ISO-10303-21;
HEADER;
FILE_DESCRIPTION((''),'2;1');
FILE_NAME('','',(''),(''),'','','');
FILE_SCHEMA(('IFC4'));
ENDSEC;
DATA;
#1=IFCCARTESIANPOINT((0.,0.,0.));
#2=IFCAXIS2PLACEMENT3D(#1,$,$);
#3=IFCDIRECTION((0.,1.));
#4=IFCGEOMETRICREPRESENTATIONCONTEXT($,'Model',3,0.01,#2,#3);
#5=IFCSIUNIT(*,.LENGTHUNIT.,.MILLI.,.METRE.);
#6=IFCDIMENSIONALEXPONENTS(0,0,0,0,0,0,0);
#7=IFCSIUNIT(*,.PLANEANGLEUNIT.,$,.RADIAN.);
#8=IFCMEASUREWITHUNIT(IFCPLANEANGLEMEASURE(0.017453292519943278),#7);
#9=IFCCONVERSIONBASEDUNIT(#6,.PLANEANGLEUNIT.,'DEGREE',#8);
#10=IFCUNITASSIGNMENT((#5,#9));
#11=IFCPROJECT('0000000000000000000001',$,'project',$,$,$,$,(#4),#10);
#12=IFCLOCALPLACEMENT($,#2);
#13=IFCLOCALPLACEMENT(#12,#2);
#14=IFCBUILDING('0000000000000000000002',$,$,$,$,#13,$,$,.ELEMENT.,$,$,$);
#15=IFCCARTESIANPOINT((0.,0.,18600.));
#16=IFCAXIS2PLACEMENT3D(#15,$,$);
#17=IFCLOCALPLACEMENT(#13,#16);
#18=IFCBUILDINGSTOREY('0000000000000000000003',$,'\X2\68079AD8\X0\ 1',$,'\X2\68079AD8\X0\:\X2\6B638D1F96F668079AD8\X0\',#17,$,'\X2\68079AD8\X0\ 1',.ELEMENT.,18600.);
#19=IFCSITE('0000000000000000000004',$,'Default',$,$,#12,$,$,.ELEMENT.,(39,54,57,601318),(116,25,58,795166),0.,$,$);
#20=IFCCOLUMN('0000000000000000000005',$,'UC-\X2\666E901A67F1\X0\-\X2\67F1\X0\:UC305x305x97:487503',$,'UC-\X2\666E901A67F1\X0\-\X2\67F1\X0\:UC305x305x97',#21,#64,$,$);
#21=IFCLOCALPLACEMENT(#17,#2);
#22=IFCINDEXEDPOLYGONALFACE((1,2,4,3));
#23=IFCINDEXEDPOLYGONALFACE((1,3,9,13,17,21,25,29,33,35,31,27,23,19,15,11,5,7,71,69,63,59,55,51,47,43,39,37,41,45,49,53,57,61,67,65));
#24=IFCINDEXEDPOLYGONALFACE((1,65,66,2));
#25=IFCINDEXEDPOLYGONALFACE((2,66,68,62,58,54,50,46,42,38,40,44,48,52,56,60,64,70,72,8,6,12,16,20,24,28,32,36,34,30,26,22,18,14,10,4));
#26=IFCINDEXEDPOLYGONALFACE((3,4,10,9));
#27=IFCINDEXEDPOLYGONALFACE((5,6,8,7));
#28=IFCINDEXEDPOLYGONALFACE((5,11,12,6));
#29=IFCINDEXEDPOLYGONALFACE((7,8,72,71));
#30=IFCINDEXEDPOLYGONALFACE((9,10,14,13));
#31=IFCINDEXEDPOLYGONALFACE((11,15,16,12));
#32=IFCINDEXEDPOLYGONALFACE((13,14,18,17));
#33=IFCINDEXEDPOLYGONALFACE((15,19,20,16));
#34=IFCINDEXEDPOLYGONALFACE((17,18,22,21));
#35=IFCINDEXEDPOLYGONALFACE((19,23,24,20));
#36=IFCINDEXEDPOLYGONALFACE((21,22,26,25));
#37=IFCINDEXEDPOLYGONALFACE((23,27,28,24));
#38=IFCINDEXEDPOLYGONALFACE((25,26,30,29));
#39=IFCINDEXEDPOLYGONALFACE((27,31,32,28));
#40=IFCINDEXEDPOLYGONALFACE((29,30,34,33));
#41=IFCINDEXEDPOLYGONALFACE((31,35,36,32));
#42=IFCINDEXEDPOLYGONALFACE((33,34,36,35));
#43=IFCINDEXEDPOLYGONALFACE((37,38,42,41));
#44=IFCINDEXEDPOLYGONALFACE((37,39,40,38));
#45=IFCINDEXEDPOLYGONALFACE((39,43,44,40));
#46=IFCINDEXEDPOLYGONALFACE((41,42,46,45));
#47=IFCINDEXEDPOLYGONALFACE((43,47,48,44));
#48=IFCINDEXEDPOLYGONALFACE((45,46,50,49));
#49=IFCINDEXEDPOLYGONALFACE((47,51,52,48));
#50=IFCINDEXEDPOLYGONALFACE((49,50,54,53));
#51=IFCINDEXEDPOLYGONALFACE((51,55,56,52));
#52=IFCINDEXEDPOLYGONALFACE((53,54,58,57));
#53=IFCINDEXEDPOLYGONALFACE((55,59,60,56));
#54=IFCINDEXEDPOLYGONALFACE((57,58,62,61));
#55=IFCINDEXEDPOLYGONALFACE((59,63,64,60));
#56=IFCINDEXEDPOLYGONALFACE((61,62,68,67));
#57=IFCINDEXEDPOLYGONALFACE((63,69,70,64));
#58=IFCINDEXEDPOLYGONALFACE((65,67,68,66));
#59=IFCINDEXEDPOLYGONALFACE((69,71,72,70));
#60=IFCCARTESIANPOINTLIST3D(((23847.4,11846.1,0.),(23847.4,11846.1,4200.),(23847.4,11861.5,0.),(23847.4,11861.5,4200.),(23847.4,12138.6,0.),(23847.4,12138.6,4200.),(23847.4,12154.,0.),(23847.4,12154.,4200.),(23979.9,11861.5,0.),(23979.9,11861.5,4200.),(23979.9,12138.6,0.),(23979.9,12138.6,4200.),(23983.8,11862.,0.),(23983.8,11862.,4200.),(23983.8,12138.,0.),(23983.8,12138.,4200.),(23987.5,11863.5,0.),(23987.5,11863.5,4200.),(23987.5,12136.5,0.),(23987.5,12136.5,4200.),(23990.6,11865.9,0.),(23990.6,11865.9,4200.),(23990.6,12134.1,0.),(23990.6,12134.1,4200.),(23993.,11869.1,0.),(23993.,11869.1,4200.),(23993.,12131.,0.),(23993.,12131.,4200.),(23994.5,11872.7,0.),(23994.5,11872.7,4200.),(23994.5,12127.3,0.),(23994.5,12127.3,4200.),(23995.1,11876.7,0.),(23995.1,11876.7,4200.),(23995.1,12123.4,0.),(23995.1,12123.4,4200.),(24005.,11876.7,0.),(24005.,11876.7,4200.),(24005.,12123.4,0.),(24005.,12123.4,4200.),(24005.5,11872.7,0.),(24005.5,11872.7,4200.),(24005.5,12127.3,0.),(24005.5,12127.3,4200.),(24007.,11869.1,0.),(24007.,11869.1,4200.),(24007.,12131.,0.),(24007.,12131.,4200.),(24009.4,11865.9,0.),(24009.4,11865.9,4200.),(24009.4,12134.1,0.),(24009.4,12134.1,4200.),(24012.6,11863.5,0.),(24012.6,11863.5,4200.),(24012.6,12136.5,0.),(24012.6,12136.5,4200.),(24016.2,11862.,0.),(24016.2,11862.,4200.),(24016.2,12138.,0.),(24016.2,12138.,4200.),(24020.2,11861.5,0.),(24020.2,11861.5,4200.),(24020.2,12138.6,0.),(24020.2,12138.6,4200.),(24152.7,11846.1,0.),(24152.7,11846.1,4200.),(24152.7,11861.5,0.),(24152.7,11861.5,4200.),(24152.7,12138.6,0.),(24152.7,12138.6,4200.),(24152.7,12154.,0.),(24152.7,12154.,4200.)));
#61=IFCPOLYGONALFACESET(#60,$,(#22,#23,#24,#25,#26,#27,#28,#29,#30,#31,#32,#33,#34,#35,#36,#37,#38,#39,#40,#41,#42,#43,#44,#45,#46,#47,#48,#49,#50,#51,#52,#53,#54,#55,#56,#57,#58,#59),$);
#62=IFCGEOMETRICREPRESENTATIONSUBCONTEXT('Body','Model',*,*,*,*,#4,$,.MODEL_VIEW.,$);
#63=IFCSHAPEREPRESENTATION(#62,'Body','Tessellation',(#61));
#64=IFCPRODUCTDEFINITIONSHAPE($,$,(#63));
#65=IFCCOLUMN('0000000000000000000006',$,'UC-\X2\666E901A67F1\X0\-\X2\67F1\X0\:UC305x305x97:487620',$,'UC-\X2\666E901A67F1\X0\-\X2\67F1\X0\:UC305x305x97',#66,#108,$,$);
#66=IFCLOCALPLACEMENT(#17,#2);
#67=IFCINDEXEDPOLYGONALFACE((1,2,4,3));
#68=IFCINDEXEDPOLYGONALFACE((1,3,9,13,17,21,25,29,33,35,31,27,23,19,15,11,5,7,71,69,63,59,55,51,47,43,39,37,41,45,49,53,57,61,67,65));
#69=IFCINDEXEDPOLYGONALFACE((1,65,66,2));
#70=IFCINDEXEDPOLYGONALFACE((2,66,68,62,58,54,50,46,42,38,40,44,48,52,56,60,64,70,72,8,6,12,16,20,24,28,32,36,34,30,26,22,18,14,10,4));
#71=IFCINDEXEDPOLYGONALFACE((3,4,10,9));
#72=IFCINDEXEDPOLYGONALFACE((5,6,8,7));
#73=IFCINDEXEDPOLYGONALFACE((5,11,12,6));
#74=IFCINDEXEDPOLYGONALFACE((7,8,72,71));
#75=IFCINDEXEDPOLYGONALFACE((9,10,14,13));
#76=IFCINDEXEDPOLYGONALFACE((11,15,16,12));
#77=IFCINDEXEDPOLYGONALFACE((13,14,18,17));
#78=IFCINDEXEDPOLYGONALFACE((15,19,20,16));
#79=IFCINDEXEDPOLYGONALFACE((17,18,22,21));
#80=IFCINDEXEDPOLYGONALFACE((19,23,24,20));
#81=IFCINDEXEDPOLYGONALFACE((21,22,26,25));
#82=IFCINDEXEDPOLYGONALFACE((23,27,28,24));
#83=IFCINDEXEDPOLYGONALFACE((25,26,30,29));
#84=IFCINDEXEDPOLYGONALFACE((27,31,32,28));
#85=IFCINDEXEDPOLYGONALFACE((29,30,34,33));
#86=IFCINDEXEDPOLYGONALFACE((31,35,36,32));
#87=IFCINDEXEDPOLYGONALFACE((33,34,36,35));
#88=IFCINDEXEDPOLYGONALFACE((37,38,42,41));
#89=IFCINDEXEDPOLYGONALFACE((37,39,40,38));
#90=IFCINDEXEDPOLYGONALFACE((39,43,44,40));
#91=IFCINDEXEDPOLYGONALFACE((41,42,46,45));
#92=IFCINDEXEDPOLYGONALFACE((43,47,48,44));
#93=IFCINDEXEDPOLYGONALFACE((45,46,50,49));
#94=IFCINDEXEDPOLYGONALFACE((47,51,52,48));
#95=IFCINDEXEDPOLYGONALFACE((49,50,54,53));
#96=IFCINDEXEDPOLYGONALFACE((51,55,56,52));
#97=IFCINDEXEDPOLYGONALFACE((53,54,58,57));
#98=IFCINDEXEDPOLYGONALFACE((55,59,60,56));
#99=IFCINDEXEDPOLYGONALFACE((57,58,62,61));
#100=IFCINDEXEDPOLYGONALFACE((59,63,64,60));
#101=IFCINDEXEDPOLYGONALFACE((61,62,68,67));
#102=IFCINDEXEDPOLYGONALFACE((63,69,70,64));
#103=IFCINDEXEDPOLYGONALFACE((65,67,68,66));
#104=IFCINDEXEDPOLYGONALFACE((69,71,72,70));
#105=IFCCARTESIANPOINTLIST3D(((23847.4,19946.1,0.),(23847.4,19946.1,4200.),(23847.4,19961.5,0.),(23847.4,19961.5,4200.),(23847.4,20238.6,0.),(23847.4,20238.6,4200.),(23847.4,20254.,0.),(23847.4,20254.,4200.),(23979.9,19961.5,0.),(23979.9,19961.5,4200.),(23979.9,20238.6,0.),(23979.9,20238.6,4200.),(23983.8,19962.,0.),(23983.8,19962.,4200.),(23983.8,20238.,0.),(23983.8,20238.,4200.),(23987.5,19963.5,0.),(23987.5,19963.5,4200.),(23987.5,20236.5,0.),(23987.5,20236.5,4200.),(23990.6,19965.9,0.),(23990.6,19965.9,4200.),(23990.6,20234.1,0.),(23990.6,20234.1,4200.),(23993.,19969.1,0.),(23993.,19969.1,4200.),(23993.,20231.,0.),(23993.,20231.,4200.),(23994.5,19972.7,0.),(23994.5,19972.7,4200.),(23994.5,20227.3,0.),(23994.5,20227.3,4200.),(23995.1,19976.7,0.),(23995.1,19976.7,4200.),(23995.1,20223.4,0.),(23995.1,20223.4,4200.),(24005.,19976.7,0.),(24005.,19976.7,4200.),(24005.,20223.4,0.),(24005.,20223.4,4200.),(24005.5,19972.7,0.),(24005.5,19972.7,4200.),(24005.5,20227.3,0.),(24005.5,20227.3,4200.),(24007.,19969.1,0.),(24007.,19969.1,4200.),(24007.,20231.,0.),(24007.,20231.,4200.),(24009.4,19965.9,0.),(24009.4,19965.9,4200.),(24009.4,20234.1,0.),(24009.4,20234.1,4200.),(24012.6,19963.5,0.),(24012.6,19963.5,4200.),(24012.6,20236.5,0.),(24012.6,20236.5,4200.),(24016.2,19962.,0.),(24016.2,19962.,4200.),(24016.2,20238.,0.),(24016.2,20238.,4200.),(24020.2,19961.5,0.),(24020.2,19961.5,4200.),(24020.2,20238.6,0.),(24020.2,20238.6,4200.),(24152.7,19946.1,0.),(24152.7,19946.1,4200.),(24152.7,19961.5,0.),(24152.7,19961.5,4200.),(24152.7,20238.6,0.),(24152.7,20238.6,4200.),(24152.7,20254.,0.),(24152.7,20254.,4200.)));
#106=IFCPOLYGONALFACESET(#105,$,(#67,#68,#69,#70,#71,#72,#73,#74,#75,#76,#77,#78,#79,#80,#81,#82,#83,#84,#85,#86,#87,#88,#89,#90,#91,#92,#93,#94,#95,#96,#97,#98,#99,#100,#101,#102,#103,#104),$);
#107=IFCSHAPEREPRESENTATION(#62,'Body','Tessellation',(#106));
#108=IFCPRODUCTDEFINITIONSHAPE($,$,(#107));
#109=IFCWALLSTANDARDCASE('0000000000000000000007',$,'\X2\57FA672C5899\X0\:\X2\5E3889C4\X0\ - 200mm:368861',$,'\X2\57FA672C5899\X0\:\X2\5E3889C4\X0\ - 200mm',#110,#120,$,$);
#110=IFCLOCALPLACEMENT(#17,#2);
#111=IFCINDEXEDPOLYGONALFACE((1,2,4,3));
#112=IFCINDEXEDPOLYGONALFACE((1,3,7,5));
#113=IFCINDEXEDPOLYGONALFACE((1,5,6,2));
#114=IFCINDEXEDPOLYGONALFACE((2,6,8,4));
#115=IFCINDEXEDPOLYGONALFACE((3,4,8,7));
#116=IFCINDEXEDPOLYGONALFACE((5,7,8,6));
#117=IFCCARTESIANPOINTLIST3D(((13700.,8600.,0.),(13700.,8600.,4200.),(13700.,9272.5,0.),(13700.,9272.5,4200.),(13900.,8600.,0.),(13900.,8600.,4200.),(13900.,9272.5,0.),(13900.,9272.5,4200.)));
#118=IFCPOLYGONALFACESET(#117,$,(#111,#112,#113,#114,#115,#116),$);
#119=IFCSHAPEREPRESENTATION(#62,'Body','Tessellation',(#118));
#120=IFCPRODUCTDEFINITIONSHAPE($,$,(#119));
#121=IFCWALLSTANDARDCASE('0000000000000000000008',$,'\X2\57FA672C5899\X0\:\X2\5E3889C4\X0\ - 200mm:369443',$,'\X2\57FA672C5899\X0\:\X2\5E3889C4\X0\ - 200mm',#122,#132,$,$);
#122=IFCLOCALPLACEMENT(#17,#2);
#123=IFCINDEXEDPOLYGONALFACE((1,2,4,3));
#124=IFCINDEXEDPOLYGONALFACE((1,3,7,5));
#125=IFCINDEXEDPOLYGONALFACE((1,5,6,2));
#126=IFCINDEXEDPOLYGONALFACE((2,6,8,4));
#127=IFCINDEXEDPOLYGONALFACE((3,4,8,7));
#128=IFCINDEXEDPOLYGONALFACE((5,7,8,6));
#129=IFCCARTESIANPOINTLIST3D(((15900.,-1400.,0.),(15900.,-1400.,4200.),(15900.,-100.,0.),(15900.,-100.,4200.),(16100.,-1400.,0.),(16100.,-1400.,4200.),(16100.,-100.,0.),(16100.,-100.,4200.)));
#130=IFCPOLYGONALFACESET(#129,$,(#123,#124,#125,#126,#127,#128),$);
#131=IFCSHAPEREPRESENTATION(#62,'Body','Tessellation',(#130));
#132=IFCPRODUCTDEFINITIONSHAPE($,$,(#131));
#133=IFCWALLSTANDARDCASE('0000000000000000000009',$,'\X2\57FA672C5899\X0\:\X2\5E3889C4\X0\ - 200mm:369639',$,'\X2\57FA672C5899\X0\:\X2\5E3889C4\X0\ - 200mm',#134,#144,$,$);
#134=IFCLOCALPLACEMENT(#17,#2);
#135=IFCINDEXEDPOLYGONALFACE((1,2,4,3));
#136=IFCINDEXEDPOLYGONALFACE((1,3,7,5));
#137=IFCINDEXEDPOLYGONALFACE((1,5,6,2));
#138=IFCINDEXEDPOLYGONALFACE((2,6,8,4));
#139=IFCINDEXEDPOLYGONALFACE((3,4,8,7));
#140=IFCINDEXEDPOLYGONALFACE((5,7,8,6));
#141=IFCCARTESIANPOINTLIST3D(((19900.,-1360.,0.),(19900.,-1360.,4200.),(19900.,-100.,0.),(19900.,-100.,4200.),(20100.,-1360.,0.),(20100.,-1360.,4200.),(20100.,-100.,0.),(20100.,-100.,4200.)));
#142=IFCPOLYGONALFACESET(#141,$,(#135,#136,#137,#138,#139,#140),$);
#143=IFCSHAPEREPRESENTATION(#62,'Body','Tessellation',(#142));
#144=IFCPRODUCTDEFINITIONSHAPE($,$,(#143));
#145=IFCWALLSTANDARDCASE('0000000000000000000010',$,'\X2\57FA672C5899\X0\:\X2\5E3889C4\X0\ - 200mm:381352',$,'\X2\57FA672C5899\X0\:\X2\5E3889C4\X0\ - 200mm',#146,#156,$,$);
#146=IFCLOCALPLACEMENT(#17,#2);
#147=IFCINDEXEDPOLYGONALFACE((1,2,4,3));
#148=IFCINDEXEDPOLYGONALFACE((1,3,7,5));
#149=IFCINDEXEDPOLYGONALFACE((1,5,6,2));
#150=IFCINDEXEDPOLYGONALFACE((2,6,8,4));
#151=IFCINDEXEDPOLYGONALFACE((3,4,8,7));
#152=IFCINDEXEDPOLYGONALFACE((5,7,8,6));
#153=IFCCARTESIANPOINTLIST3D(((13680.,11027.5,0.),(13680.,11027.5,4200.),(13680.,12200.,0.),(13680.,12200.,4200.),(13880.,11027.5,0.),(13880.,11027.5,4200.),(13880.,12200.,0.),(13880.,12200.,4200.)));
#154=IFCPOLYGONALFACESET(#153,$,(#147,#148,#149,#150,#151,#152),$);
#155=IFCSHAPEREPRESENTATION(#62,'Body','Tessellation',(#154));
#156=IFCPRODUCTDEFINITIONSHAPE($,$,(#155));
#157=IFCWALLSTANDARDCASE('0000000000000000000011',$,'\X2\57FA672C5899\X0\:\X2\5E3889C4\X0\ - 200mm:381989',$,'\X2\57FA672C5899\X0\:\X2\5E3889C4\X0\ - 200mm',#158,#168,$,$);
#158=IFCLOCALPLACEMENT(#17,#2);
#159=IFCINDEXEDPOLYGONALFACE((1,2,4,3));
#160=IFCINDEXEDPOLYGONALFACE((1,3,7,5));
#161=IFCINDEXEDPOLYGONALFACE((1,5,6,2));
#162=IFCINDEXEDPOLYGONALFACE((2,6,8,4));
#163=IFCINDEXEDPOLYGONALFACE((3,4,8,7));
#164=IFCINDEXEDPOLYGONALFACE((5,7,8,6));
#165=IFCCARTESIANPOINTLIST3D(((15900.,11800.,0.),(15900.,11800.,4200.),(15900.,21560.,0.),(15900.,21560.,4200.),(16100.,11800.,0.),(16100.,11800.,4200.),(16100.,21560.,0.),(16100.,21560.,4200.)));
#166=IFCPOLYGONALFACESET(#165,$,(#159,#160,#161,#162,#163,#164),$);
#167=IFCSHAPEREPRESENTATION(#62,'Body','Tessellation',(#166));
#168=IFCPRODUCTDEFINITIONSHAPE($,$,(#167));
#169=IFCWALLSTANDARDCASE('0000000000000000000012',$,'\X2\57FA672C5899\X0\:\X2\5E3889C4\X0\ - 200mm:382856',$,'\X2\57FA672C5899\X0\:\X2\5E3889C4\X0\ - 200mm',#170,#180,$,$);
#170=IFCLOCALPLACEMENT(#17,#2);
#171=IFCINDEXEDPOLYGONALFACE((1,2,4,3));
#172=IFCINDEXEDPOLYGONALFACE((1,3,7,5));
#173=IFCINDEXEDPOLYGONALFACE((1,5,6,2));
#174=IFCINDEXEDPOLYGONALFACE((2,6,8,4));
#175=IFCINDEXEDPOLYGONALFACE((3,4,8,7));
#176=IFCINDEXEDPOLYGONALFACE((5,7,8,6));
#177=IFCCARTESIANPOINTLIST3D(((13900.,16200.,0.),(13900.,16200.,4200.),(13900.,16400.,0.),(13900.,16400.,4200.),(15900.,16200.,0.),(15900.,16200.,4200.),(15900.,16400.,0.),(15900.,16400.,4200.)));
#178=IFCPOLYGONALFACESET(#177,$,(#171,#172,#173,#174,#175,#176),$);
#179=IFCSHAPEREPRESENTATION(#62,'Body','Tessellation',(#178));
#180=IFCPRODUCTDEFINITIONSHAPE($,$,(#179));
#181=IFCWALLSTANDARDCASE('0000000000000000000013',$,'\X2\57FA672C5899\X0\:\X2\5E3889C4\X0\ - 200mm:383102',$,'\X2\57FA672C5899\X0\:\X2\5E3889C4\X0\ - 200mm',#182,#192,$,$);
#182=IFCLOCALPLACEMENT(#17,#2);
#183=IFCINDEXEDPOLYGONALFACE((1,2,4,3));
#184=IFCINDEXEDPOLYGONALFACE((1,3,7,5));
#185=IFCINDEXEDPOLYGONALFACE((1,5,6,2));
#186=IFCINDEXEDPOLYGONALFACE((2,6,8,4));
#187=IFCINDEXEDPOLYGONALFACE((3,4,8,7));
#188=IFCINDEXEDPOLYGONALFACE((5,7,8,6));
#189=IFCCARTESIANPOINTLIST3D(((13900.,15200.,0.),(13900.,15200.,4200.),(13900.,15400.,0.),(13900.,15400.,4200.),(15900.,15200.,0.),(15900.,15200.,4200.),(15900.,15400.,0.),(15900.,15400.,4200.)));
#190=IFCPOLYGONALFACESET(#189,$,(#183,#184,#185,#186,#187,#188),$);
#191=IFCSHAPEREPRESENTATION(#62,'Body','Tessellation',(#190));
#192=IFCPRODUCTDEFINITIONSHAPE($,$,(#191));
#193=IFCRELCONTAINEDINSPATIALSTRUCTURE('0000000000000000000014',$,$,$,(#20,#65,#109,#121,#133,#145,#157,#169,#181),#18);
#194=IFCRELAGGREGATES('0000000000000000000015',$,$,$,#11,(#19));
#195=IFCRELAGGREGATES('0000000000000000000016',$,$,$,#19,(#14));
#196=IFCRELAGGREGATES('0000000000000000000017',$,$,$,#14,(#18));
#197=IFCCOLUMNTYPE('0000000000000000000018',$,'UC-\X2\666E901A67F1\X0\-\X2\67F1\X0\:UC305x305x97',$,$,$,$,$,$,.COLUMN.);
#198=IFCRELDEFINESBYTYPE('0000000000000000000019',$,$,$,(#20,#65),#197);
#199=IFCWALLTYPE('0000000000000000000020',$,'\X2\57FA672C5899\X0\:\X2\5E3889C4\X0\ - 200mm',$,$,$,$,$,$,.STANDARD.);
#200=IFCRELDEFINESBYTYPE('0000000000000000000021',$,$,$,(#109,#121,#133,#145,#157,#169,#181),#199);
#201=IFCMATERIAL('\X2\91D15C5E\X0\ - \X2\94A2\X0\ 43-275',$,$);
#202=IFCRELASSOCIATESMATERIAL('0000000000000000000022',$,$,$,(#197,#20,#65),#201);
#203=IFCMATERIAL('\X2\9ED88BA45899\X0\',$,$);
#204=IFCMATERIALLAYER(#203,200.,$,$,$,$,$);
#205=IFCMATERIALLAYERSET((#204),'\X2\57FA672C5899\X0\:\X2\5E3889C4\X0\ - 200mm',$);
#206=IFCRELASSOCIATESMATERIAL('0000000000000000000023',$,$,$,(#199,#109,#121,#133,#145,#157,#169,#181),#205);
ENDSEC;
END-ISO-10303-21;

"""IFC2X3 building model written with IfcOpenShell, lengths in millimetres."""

from ifc_helpers import new_model, entity, si_unit, converted_unit, direction, frame, frame_2d, origin, origin_2d_with_axis, place, context, subcontext, project, spatial, rectangle, i_section, extrude, source, transform, mapped, material, layer, layer_set, layer_usage, type_object, type_shapes, element, save


model = new_model("IFC2X3")

# Units and contexts
model_context = context("Model", 3, precision=0.01, world=origin(), true_north=direction((0.0, 1.0)))
body_context = subcontext(model_context, "Body", "Model", "MODEL_VIEW")
ifc_project = project(units=[si_unit("LENGTHUNIT", "METRE", prefix="MILLI"), converted_unit("PLANEANGLEUNIT", "DEGREE", entity("IfcPlaneAngleMeasure", 0.017453292519943278), si_unit("PLANEANGLEUNIT", "RADIAN"), dimensions=[0, 0, 0, 0, 0, 0, 0])], contexts=[model_context])

# Site, building, storey
site_placement = place(None, origin())
site = spatial("IfcSite", under=ifc_project, at=site_placement, Name="Default", CompositionType="ELEMENT", RefLatitude=(39, 54, 57, 601318), RefLongitude=(116, 25, 58, 795166), RefElevation=0.0)
building_placement = place(site_placement, origin())
building = spatial("IfcBuilding", under=site, at=building_placement, CompositionType="ELEMENT")
storey_placement = place(building_placement, frame((0.0, 0.0, 18600.0)))
storey = spatial("IfcBuildingStorey", under=building, at=storey_placement, Name="标高 1", ObjectType="标高:正负零标高", LongName="标高 1", CompositionType="ELEMENT", Elevation=18600.0)

# Columns
ifc_material_1 = material(Name="金属 - 钢 43-275")
column_type = type_object("IfcColumnType", Name="UC-普通柱-柱:UC305x305x97", PredefinedType="COLUMN", material=ifc_material_1)
shared_shape = source(origin(), body_context, "Body", "SweptSolid", [
    extrude(i_section(OverallWidth=305.3, OverallDepth=307.9, WebThickness=9.9, FlangeThickness=15.4, FilletRadius=15.2, at=origin_2d_with_axis()), frame((0.0, 0.0, 18600.0), z_axis=(0.0, 0.0, 1.0), x_axis=(-1.0, 0.0, 0.0)), (0.0, 0.0, 1.0), 4200.0),
])
type_shapes(column_type, [shared_shape])
for number, where, name in (
    (1, (24000.0, 12000.0, -18600.0), "UC-普通柱-柱:UC305x305x97:487503"),
    (2, (24000.0, 20100.0, -18600.0), "UC-普通柱-柱:UC305x305x97:487620"),
):
    element("IfcColumn", number, at=place(storey_placement, frame(where)), inside=storey, type_object=column_type, material=ifc_material_1, Name=name, ObjectType="UC-普通柱-柱:UC305x305x97", context=body_context, shape_type="MappedRepresentation", body=[
        mapped(shared_shape, transform((0.0, 0.0, 0.0), scale=1.0)),
    ])

# Walls
ifc_material_2 = material(Name="默认墙")
ifc_layer = layer(ifc_material_2, 200.0)
ifc_layer_set = layer_set([ifc_layer], Name="基本墙:常规 - 200mm")
ifc_layer_usage_1 = layer_usage(ifc_layer_set, "AXIS2", "NEGATIVE", 100.0)
wall_type = type_object("IfcWallType", Name="基本墙:常规 - 200mm", PredefinedType="STANDARD", material=ifc_layer_set)
wall_1_placement = place(storey_placement, frame((13800.0, 8600.0, 0.0), z_axis=(0.0, 0.0, 1.0), x_axis=(0.0, 1.0, 0.0)))
element("IfcWallStandardCase", 3, at=wall_1_placement, inside=storey, type_object=wall_type, material=ifc_layer_usage_1, Name="基本墙:常规 - 200mm:368861", ObjectType="基本墙:常规 - 200mm", context=body_context, shape_type="SweptSolid", body=[
    extrude(rectangle(XDim=672.5, YDim=200.0, at=frame_2d((336.2, 0.0), x_axis=(-1.0, 0.0))), origin(), (0.0, 0.0, 1.0), 4200.0),
])
ifc_layer_usage_2 = layer_usage(ifc_layer_set, "AXIS2", "NEGATIVE", 100.0)
wall_2_placement = place(storey_placement, frame((16000.0, -1400.0, 0.0), z_axis=(0.0, 0.0, 1.0), x_axis=(0.0, 1.0, 0.0)))
element("IfcWallStandardCase", 4, at=wall_2_placement, inside=storey, type_object=wall_type, material=ifc_layer_usage_2, Name="基本墙:常规 - 200mm:369443", ObjectType="基本墙:常规 - 200mm", context=body_context, shape_type="SweptSolid", body=[
    extrude(rectangle(XDim=1300.0, YDim=200.0, at=frame_2d((650.0, 0.0), x_axis=(-1.0, 0.0))), origin(), (0.0, 0.0, 1.0), 4200.0),
])
ifc_layer_usage_3 = layer_usage(ifc_layer_set, "AXIS2", "NEGATIVE", 100.0)
wall_3_placement = place(storey_placement, frame((20000.0, -100.0, 0.0), z_axis=(0.0, 0.0, 1.0), x_axis=(0.0, -1.0, 0.0)))
element("IfcWallStandardCase", 5, at=wall_3_placement, inside=storey, type_object=wall_type, material=ifc_layer_usage_3, Name="基本墙:常规 - 200mm:369639", ObjectType="基本墙:常规 - 200mm", context=body_context, shape_type="SweptSolid", body=[
    extrude(rectangle(XDim=1260.0, YDim=200.0, at=frame_2d((630.0, 0.0), x_axis=(-1.0, 0.0))), origin(), (0.0, 0.0, 1.0), 4200.0),
])
ifc_layer_usage_4 = layer_usage(ifc_layer_set, "AXIS2", "NEGATIVE", 100.0)
wall_4_placement = place(storey_placement, frame((13780.0, 11027.5, 0.0), z_axis=(0.0, 0.0, 1.0), x_axis=(0.0, 1.0, 0.0)))
element("IfcWallStandardCase", 6, at=wall_4_placement, inside=storey, type_object=wall_type, material=ifc_layer_usage_4, Name="基本墙:常规 - 200mm:381352", ObjectType="基本墙:常规 - 200mm", context=body_context, shape_type="SweptSolid", body=[
    extrude(rectangle(XDim=1172.5, YDim=200.0, at=frame_2d((586.3, 0.0), x_axis=(-1.0, 0.0))), origin(), (0.0, 0.0, 1.0), 4200.0),
])
ifc_layer_usage_5 = layer_usage(ifc_layer_set, "AXIS2", "NEGATIVE", 100.0)
wall_5_placement = place(storey_placement, frame((16000.0, 11800.0, 0.0), z_axis=(0.0, 0.0, 1.0), x_axis=(0.0, 1.0, 0.0)))
element("IfcWallStandardCase", 7, at=wall_5_placement, inside=storey, type_object=wall_type, material=ifc_layer_usage_5, Name="基本墙:常规 - 200mm:381989", ObjectType="基本墙:常规 - 200mm", context=body_context, shape_type="SweptSolid", body=[
    extrude(rectangle(XDim=9760.0, YDim=200.0, at=frame_2d((4880.0, 0.0), x_axis=(-1.0, 0.0))), origin(), (0.0, 0.0, 1.0), 4200.0),
])
ifc_layer_usage_6 = layer_usage(ifc_layer_set, "AXIS2", "NEGATIVE", 100.0)
wall_6_placement = place(storey_placement, frame((13900.0, 16300.0, 0.0)))
element("IfcWallStandardCase", 8, at=wall_6_placement, inside=storey, type_object=wall_type, material=ifc_layer_usage_6, Name="基本墙:常规 - 200mm:382856", ObjectType="基本墙:常规 - 200mm", context=body_context, shape_type="SweptSolid", body=[
    extrude(rectangle(XDim=2000.0, YDim=200.0, at=frame_2d((1000.0, 0.0), x_axis=(-1.0, 0.0))), origin(), (0.0, 0.0, 1.0), 4200.0),
])
ifc_layer_usage_7 = layer_usage(ifc_layer_set, "AXIS2", "NEGATIVE", 100.0)
wall_7_placement = place(storey_placement, frame((13900.0, 15300.0, 0.0)))
element("IfcWallStandardCase", 9, at=wall_7_placement, inside=storey, type_object=wall_type, material=ifc_layer_usage_7, Name="基本墙:常规 - 200mm:383102", ObjectType="基本墙:常规 - 200mm", context=body_context, shape_type="SweptSolid", body=[
    extrude(rectangle(XDim=2000.0, YDim=200.0, at=frame_2d((1000.0, 0.0), x_axis=(-1.0, 0.0))), origin(), (0.0, 0.0, 1.0), 4200.0),
])

save(model, "model.ifc")
